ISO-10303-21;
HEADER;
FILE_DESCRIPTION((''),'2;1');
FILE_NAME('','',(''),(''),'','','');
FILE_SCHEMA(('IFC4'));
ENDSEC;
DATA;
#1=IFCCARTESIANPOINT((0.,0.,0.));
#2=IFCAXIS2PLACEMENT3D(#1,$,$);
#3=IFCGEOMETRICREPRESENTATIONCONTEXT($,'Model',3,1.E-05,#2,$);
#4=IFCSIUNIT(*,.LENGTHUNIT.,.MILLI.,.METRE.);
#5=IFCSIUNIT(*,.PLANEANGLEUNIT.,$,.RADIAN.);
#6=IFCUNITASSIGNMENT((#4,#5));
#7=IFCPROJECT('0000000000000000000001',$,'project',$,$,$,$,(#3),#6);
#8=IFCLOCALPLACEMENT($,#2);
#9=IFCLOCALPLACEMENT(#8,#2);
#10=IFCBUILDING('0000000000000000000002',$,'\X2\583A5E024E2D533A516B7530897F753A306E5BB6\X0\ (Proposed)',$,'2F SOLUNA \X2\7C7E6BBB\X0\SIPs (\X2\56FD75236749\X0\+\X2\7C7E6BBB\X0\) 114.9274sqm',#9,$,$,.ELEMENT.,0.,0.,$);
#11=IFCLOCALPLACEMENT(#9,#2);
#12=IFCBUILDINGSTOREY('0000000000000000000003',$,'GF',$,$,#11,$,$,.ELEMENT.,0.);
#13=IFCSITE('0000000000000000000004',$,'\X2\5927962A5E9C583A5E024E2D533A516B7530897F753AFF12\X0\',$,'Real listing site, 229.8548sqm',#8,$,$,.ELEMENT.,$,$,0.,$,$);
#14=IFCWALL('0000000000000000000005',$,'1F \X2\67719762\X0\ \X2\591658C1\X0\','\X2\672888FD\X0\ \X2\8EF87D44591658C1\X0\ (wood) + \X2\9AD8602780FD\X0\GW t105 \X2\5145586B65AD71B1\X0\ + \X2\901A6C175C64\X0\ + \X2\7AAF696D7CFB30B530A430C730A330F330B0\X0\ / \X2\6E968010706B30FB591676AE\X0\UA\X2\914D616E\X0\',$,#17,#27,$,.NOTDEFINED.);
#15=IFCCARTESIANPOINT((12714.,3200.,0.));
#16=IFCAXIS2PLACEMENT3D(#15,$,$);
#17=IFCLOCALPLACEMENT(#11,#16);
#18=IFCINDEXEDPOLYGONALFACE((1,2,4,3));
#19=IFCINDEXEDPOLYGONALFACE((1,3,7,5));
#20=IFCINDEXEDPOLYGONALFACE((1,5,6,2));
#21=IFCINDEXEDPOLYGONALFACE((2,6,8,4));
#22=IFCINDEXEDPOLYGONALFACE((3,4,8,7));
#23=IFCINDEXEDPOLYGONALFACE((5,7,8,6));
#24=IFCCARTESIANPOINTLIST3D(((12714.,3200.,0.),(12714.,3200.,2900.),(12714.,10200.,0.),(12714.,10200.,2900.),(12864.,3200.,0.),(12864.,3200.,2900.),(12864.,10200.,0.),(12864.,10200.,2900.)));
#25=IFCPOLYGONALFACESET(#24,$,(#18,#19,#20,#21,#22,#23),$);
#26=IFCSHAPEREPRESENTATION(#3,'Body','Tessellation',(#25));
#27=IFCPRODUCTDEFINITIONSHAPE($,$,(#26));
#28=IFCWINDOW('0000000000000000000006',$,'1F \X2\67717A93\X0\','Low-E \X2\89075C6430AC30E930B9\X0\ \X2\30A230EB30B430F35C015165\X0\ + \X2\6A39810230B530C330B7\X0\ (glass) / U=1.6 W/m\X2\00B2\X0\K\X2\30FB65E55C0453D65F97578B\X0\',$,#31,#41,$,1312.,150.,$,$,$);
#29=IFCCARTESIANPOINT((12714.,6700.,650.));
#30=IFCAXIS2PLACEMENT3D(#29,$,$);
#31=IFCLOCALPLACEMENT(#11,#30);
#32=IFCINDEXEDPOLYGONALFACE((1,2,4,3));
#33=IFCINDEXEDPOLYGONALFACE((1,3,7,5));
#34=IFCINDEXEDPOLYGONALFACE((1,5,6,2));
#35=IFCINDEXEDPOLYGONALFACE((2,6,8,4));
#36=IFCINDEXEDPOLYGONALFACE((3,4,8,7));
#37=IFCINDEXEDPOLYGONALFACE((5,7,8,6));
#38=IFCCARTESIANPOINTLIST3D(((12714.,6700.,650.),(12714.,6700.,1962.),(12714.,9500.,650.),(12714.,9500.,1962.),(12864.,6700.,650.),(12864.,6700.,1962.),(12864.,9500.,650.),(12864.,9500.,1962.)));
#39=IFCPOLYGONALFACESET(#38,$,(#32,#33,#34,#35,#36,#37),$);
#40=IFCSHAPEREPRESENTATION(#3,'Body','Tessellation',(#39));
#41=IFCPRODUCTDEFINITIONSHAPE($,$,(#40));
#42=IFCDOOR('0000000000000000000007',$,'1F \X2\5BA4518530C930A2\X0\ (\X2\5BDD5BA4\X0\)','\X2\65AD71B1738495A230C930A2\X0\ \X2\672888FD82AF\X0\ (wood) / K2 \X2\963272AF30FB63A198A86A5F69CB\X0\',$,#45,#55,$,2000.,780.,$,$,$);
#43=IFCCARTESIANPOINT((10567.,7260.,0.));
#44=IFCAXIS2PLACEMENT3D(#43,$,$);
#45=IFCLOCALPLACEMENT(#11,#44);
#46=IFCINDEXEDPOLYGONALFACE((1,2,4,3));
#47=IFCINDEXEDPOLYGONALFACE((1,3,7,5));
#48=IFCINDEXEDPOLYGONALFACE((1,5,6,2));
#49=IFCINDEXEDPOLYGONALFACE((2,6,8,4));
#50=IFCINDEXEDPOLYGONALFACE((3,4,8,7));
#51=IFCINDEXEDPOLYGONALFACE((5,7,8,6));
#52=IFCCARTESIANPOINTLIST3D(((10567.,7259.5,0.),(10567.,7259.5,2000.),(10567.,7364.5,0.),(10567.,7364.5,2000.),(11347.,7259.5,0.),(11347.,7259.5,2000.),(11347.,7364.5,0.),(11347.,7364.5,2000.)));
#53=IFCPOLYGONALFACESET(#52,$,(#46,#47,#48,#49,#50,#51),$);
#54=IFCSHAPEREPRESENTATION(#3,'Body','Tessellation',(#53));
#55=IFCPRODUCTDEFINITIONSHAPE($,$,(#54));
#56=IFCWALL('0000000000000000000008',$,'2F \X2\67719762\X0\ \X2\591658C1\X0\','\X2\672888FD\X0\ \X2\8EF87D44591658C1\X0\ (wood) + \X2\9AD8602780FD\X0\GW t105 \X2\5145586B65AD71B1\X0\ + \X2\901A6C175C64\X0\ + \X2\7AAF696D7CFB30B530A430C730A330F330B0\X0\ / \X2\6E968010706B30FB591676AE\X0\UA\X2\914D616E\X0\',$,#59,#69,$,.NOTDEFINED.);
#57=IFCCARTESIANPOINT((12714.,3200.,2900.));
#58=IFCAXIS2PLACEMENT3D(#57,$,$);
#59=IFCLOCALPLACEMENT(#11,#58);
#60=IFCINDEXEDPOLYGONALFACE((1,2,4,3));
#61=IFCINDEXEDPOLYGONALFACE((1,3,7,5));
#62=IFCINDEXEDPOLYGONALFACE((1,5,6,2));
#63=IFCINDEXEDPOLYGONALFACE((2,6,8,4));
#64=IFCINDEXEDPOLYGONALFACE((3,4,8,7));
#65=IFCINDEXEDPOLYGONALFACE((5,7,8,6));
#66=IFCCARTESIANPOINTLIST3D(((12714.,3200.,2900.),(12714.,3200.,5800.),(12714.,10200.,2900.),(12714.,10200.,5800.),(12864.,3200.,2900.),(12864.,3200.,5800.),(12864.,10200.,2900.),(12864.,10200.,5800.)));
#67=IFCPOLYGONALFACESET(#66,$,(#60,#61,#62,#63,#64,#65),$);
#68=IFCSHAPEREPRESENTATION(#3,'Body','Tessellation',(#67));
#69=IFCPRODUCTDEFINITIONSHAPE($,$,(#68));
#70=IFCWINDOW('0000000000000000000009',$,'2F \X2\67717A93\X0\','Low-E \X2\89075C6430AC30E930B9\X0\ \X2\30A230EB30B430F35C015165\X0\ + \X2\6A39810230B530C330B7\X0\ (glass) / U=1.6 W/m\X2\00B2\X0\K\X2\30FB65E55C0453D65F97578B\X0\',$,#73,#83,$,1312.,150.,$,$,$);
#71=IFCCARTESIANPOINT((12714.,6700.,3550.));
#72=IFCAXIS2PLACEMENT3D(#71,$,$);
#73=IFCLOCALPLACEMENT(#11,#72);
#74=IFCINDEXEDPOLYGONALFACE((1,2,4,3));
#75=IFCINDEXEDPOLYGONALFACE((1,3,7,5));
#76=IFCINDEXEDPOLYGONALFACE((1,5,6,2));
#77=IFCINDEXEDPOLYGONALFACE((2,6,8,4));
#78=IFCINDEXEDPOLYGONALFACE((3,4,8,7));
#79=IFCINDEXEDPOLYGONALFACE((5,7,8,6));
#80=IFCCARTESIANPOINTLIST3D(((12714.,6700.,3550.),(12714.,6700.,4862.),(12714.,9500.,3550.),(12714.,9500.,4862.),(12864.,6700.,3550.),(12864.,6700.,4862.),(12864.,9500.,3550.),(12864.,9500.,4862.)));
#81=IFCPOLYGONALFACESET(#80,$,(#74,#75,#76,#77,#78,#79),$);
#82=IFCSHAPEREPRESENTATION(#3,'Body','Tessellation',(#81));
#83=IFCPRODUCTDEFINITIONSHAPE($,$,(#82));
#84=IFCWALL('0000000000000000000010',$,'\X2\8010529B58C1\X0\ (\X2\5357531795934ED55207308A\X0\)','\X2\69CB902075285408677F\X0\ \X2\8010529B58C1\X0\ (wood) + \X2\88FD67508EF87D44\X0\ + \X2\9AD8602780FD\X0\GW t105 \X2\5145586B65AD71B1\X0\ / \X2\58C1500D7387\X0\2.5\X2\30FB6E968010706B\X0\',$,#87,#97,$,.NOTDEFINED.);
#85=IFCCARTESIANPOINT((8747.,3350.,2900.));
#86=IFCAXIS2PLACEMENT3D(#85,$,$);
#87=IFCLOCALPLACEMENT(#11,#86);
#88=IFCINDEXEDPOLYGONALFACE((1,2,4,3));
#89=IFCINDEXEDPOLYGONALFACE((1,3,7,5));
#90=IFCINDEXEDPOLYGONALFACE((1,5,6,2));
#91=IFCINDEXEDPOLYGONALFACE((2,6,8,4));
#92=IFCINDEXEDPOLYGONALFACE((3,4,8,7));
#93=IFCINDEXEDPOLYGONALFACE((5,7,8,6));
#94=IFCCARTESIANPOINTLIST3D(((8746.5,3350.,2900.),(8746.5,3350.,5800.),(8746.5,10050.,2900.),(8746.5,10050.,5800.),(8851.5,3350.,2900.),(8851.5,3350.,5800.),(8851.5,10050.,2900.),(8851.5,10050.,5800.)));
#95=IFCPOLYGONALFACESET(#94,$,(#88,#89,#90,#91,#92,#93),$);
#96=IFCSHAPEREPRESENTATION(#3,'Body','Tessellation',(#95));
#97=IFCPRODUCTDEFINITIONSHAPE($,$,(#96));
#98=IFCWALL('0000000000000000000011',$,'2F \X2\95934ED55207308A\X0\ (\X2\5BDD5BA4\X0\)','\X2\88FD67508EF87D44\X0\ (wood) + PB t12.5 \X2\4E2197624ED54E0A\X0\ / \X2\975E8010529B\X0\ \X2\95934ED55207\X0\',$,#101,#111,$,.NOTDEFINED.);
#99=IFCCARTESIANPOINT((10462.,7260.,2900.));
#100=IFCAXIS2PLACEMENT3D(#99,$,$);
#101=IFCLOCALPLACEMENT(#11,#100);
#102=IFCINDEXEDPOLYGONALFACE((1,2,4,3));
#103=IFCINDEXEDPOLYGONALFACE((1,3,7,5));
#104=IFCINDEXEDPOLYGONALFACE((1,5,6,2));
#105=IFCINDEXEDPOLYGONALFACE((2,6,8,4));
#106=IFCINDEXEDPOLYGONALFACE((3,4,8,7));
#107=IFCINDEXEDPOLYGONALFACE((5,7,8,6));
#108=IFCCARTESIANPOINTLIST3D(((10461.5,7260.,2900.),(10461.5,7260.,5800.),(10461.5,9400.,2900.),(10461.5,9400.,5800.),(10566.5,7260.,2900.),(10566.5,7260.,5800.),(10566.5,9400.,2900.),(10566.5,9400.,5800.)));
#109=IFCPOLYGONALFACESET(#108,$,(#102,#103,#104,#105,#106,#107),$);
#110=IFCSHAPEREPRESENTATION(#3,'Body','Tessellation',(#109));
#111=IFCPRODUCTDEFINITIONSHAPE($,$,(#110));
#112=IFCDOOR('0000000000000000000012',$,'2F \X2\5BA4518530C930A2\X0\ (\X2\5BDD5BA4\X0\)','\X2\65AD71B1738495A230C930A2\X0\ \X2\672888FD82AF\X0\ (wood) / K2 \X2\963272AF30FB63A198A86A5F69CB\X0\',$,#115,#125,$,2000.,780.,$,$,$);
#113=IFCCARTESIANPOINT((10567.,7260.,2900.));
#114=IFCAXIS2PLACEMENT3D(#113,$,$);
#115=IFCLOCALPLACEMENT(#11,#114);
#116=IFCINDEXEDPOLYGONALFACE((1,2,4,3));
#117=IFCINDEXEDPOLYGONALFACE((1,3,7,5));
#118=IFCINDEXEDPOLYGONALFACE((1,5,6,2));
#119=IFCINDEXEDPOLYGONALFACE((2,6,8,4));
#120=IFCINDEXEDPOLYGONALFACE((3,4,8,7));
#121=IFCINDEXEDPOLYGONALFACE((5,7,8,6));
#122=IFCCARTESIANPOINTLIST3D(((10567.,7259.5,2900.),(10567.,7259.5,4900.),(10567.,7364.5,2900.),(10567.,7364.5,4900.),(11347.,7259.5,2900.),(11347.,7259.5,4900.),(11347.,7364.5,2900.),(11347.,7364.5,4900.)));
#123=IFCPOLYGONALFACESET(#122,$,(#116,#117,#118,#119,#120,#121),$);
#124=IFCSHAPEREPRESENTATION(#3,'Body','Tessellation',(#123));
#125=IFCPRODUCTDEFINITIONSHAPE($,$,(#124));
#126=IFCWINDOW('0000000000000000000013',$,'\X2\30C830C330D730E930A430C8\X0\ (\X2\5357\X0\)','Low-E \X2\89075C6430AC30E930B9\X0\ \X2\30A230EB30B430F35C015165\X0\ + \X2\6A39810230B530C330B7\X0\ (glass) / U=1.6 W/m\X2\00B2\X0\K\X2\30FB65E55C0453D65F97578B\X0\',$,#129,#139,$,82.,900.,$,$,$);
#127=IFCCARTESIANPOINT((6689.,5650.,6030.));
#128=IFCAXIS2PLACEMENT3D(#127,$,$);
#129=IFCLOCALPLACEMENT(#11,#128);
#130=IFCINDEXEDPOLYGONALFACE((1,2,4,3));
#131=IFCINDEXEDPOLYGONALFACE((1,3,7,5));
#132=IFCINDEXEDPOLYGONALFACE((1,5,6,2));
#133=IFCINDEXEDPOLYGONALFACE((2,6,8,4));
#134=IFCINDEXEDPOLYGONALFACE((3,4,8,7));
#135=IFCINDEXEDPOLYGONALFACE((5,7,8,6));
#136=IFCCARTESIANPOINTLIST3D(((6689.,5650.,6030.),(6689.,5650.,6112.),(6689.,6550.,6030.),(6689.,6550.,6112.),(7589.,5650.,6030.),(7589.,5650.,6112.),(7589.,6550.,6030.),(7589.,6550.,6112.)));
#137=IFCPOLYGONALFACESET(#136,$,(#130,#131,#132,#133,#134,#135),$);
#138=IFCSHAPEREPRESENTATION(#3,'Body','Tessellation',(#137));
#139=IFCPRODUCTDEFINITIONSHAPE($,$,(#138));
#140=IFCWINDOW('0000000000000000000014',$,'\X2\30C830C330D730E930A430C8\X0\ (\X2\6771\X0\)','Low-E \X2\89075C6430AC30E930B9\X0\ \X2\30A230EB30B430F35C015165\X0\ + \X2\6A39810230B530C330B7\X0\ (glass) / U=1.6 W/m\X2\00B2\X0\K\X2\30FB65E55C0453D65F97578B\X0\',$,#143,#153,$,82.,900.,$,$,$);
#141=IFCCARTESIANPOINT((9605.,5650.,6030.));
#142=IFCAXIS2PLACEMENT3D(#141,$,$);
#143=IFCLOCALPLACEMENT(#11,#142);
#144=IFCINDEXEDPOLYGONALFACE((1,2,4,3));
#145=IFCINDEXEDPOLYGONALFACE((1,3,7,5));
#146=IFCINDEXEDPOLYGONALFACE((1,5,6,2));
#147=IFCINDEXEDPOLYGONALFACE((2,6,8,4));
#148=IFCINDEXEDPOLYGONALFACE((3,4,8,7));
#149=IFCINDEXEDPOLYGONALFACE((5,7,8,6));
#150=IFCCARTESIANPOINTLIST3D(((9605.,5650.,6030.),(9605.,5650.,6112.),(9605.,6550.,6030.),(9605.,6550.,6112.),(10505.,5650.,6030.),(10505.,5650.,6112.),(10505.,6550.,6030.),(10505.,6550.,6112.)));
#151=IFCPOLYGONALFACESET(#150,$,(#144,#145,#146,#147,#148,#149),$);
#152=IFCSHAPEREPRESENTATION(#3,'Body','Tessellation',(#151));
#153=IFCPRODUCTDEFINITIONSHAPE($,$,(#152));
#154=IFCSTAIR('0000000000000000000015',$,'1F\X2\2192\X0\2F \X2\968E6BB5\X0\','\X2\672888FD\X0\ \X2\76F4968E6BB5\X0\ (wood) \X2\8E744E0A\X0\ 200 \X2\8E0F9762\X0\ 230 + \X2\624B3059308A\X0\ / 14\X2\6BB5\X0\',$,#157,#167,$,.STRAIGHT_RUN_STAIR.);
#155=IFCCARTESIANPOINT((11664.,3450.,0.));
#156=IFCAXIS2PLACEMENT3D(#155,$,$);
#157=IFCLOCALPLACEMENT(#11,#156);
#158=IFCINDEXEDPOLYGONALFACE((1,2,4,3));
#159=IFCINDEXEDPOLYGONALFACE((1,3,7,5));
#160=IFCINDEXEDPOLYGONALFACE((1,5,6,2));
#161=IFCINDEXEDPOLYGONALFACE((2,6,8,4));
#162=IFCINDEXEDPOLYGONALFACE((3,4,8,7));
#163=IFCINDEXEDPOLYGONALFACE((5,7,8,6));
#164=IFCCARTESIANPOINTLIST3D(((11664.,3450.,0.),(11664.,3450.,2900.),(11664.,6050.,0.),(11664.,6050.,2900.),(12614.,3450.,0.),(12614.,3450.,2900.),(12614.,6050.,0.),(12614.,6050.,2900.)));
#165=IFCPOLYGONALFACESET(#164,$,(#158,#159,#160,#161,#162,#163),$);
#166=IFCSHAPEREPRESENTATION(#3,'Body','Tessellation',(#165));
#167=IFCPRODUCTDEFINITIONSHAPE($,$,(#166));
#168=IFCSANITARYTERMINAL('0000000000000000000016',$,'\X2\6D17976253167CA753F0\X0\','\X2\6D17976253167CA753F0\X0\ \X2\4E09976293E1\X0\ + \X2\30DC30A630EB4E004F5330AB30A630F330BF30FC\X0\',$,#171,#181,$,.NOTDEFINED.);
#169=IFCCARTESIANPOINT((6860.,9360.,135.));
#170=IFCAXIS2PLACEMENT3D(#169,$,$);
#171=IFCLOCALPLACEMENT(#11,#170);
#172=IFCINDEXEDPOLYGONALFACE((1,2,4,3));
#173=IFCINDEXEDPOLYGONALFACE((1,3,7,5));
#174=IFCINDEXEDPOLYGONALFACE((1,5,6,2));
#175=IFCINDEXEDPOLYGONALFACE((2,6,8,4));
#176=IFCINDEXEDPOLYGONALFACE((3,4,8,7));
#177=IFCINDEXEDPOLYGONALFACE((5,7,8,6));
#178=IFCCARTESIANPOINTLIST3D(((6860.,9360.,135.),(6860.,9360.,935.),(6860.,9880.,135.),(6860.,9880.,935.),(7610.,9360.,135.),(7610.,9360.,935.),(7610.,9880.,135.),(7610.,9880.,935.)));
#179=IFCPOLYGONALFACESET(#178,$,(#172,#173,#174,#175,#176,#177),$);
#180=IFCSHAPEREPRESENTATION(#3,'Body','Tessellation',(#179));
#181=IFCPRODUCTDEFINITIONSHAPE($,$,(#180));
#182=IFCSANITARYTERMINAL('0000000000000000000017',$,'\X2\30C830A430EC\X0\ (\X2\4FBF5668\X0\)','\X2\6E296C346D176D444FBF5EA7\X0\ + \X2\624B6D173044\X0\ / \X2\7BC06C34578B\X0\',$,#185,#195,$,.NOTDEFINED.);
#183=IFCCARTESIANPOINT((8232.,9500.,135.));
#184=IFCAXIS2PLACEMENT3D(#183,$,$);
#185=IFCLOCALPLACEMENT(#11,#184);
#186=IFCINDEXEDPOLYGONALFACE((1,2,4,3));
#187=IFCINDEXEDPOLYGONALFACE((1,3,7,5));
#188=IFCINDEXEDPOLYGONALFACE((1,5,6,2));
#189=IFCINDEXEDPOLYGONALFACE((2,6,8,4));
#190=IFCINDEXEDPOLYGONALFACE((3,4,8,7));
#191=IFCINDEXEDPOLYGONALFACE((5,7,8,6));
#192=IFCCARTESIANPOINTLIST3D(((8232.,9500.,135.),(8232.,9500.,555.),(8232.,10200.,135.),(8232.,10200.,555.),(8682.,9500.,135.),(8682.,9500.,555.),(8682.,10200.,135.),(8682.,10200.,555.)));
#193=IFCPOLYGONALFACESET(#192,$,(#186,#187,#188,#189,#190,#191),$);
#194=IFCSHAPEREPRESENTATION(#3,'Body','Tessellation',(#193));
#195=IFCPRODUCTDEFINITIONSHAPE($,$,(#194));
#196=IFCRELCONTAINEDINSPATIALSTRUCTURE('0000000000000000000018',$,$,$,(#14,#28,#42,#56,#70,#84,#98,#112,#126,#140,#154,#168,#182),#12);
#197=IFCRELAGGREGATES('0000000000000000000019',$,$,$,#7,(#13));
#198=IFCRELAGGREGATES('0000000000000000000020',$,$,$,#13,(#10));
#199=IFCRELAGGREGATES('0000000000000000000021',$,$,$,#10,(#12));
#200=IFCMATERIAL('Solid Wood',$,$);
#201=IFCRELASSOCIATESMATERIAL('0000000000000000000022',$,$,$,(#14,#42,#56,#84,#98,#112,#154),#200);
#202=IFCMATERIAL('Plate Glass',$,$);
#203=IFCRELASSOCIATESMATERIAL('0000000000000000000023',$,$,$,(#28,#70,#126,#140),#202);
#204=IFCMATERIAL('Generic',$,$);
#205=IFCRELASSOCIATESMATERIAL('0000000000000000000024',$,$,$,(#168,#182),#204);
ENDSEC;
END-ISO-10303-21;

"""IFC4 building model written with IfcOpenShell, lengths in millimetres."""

from ifc_helpers import new_model, si_unit, frame, frame_2d, origin, place, context, project, spatial, rectangle, extrude, material, element, fill, save


model = new_model("IFC4")

# Units and contexts
model_context = context("Model", 3, precision=1e-05, world=origin())
ifc_project = project(units=[si_unit("LENGTHUNIT", "METRE", prefix="MILLI"), si_unit("PLANEANGLEUNIT", "RADIAN")], contexts=[model_context])

# Site, building, storey
site_placement = place(None, origin())
site = spatial("IfcSite", under=ifc_project, at=site_placement, Name="大阪府堺市中区八田西町２", ObjectType="Real listing site, 229.8548sqm", CompositionType="ELEMENT", RefElevation=0.0)
building_placement = place(site_placement, origin())
building = spatial("IfcBuilding", under=site, at=building_placement, Name="堺市中区八田西町の家 (Proposed)", ObjectType="2F SOLUNA 籾殻SIPs (国産杉+籾殻) 114.9274sqm", CompositionType="ELEMENT", ElevationOfRefHeight=0.0, ElevationOfTerrain=0.0)
storey_placement = place(building_placement, origin())
storey = spatial("IfcBuildingStorey", under=building, at=storey_placement, Name="GF", CompositionType="ELEMENT", Elevation=0.0)

# Wall, opening, window
ifc_material_1 = material(Name="Solid Wood")
wall_1_placement = place(storey_placement, frame((12714.0, 3200.0, 0.0)))
wall_1 = element("IfcWall", 1, at=wall_1_placement, inside=storey, material=ifc_material_1, Name="1F 東面 外壁", Description="木製 軸組外壁 (wood) + 高性能GW t105 充填断熱 + 通気層 + 窯業系サイディング / 準耐火・外皮UA配慮", PredefinedType="NOTDEFINED", context=model_context, shape_type="SweptSolid", body=[
    extrude(rectangle(XDim=150.0, YDim=7000.0, at=frame_2d((75.0, 3500.0))), frame((12714.0, 3200.0, 0.0)), (0.0, 0.0, 1.0), 2900.0),
])
opening_1_placement = place(storey_placement, frame((12714.0, 6700.0, 650.0)))
opening_1 = element("IfcOpeningElement", 2, at=opening_1_placement, cuts=wall_1, PredefinedType="NOTDEFINED", context=model_context, shape_type="SweptSolid", body=[
    extrude(rectangle(XDim=150.0, YDim=2800.0, at=frame_2d((75.0, 1400.0))), frame((12714.0, 6700.0, 650.0)), (0.0, 0.0, 1.0), 1312.0),
])
ifc_material_2 = material(Name="Plate Glass")
window_1_placement = place(storey_placement, frame((12714.0, 6700.0, 650.0)))
window_1 = element("IfcWindow", 3, at=window_1_placement, inside=storey, material=ifc_material_2, Name="1F 東窓", Description="Low-E 複層ガラス アルゴン封入 + 樹脂サッシ (glass) / U=1.6 W/m²K・日射取得型", OverallHeight=1312.0, OverallWidth=150.0, context=model_context, shape_type="SweptSolid", body=[
    extrude(rectangle(XDim=150.0, YDim=2800.0, at=frame_2d((75.0, 1400.0))), frame((12714.0, 6700.0, 650.0)), (0.0, 0.0, 1.0), 1312.0),
])
fill(opening_1, window_1)

# Door
door_1_placement = place(storey_placement, frame((10567.0, 7260.0, 0.0)))
element("IfcDoor", 4, at=door_1_placement, inside=storey, material=ifc_material_1, Name="1F 室内ドア (寝室)", Description="断熱玄関ドア 木製芯 (wood) / K2 防犯・採風機構", OverallHeight=2000.0, OverallWidth=780.0, context=model_context, shape_type="SweptSolid", body=[
    extrude(rectangle(XDim=780.0, YDim=105.0, at=frame_2d((390.0, 52.0))), frame((10567.0, 7260.0, 0.0)), (0.0, 0.0, 1.0), 2000.0),
])

# Wall, opening, window
wall_2_placement = place(storey_placement, frame((12714.0, 3200.0, 2900.0)))
wall_2 = element("IfcWall", 5, at=wall_2_placement, inside=storey, material=ifc_material_1, Name="2F 東面 外壁", Description="木製 軸組外壁 (wood) + 高性能GW t105 充填断熱 + 通気層 + 窯業系サイディング / 準耐火・外皮UA配慮", PredefinedType="NOTDEFINED", context=model_context, shape_type="SweptSolid", body=[
    extrude(rectangle(XDim=150.0, YDim=7000.0, at=frame_2d((75.0, 3500.0))), frame((12714.0, 3200.0, 2900.0)), (0.0, 0.0, 1.0), 2900.0),
])
opening_2_placement = place(storey_placement, frame((12714.0, 6700.0, 3550.0)))
opening_2 = element("IfcOpeningElement", 6, at=opening_2_placement, cuts=wall_2, PredefinedType="NOTDEFINED", context=model_context, shape_type="SweptSolid", body=[
    extrude(rectangle(XDim=150.0, YDim=2800.0, at=frame_2d((75.0, 1400.0))), frame((12714.0, 6700.0, 3550.0)), (0.0, 0.0, 1.0), 1312.0),
])
window_2_placement = place(storey_placement, frame((12714.0, 6700.0, 3550.0)))
window_2 = element("IfcWindow", 7, at=window_2_placement, inside=storey, material=ifc_material_2, Name="2F 東窓", Description="Low-E 複層ガラス アルゴン封入 + 樹脂サッシ (glass) / U=1.6 W/m²K・日射取得型", OverallHeight=1312.0, OverallWidth=150.0, context=model_context, shape_type="SweptSolid", body=[
    extrude(rectangle(XDim=150.0, YDim=2800.0, at=frame_2d((75.0, 1400.0))), frame((12714.0, 6700.0, 3550.0)), (0.0, 0.0, 1.0), 1312.0),
])
fill(opening_2, window_2)

# Walls
wall_3_placement = place(storey_placement, frame((8747.0, 3350.0, 2900.0)))
element("IfcWall", 8, at=wall_3_placement, inside=storey, material=ifc_material_1, Name="耐力壁 (南北間仕切り)", Description="構造用合板 耐力壁 (wood) + 製材軸組 + 高性能GW t105 充填断熱 / 壁倍率2.5・準耐火", PredefinedType="NOTDEFINED", context=model_context, shape_type="SweptSolid", body=[
    extrude(rectangle(XDim=105.0, YDim=6700.0, at=frame_2d((52.0, 3350.0))), frame((8747.0, 3350.0, 2900.0)), (0.0, 0.0, 1.0), 2900.0),
])
wall_4_placement = place(storey_placement, frame((10462.0, 7260.0, 2900.0)))
element("IfcWall", 9, at=wall_4_placement, inside=storey, material=ifc_material_1, Name="2F 間仕切り (寝室)", Description="製材軸組 (wood) + PB t12.5 両面仕上 / 非耐力 間仕切", PredefinedType="NOTDEFINED", context=model_context, shape_type="SweptSolid", body=[
    extrude(rectangle(XDim=105.0, YDim=2140.0, at=frame_2d((52.0, 1070.0))), frame((10462.0, 7260.0, 2900.0)), (0.0, 0.0, 1.0), 2900.0),
])

# Door
door_2_placement = place(storey_placement, frame((10567.0, 7260.0, 2900.0)))
element("IfcDoor", 10, at=door_2_placement, inside=storey, material=ifc_material_1, Name="2F 室内ドア (寝室)", Description="断熱玄関ドア 木製芯 (wood) / K2 防犯・採風機構", OverallHeight=2000.0, OverallWidth=780.0, context=model_context, shape_type="SweptSolid", body=[
    extrude(rectangle(XDim=780.0, YDim=105.0, at=frame_2d((390.0, 52.0))), frame((10567.0, 7260.0, 2900.0)), (0.0, 0.0, 1.0), 2000.0),
])

# Windows
window_3_placement = place(storey_placement, frame((6689.0, 5650.0, 6030.0)))
element("IfcWindow", 11, at=window_3_placement, inside=storey, material=ifc_material_2, Name="トップライト (南)", Description="Low-E 複層ガラス アルゴン封入 + 樹脂サッシ (glass) / U=1.6 W/m²K・日射取得型", OverallHeight=82.0, OverallWidth=900.0, context=model_context, shape_type="SweptSolid", body=[
    extrude(rectangle(XDim=900.0, YDim=900.0, at=frame_2d((450.0, 450.0))), frame((6689.0, 5650.0, 6030.0)), (0.0, 0.0, 1.0), 82.0),
])
window_4_placement = place(storey_placement, frame((9605.0, 5650.0, 6030.0)))
element("IfcWindow", 12, at=window_4_placement, inside=storey, material=ifc_material_2, Name="トップライト (東)", Description="Low-E 複層ガラス アルゴン封入 + 樹脂サッシ (glass) / U=1.6 W/m²K・日射取得型", OverallHeight=82.0, OverallWidth=900.0, context=model_context, shape_type="SweptSolid", body=[
    extrude(rectangle(XDim=900.0, YDim=900.0, at=frame_2d((450.0, 450.0))), frame((9605.0, 5650.0, 6030.0)), (0.0, 0.0, 1.0), 82.0),
])

# Stair
stair_placement = place(storey_placement, frame((11664.0, 3450.0, 0.0)))
element("IfcStair", 13, at=stair_placement, inside=storey, material=ifc_material_1, Name="1F→2F 階段", Description="木製 直階段 (wood) 蹴上 200 踏面 230 + 手すり / 14段", PredefinedType="STRAIGHT_RUN_STAIR", context=model_context, shape_type="SweptSolid", body=[
    extrude(rectangle(XDim=950.0, YDim=2600.0, at=frame_2d((475.0, 1300.0))), frame((11664.0, 3450.0, 0.0)), (0.0, 0.0, 1.0), 2900.0),
])

# Sanitary terminals
ifc_material_3 = material(Name="Generic")
sanitary_terminal_1_placement = place(storey_placement, frame((6860.0, 9360.0, 135.0)))
element("IfcSanitaryTerminal", 14, at=sanitary_terminal_1_placement, inside=storey, material=ifc_material_3, Name="洗面化粧台", Description="洗面化粧台 三面鏡 + ボウル一体カウンター", PredefinedType="NOTDEFINED", context=model_context, shape_type="SweptSolid", body=[
    extrude(rectangle(XDim=750.0, YDim=520.0, at=frame_2d((375.0, 260.0))), frame((6860.0, 9360.0, 135.0)), (0.0, 0.0, 1.0), 800.0),
])
sanitary_terminal_2_placement = place(storey_placement, frame((8232.0, 9500.0, 135.0)))
element("IfcSanitaryTerminal", 15, at=sanitary_terminal_2_placement, inside=storey, material=ifc_material_3, Name="トイレ (便器)", Description="温水洗浄便座 + 手洗い / 節水型", PredefinedType="NOTDEFINED", context=model_context, shape_type="SweptSolid", body=[
    extrude(rectangle(XDim=450.0, YDim=700.0, at=frame_2d((225.0, 350.0))), frame((8232.0, 9500.0, 135.0)), (0.0, 0.0, 1.0), 420.0),
])

save(model, "model.ifc")
